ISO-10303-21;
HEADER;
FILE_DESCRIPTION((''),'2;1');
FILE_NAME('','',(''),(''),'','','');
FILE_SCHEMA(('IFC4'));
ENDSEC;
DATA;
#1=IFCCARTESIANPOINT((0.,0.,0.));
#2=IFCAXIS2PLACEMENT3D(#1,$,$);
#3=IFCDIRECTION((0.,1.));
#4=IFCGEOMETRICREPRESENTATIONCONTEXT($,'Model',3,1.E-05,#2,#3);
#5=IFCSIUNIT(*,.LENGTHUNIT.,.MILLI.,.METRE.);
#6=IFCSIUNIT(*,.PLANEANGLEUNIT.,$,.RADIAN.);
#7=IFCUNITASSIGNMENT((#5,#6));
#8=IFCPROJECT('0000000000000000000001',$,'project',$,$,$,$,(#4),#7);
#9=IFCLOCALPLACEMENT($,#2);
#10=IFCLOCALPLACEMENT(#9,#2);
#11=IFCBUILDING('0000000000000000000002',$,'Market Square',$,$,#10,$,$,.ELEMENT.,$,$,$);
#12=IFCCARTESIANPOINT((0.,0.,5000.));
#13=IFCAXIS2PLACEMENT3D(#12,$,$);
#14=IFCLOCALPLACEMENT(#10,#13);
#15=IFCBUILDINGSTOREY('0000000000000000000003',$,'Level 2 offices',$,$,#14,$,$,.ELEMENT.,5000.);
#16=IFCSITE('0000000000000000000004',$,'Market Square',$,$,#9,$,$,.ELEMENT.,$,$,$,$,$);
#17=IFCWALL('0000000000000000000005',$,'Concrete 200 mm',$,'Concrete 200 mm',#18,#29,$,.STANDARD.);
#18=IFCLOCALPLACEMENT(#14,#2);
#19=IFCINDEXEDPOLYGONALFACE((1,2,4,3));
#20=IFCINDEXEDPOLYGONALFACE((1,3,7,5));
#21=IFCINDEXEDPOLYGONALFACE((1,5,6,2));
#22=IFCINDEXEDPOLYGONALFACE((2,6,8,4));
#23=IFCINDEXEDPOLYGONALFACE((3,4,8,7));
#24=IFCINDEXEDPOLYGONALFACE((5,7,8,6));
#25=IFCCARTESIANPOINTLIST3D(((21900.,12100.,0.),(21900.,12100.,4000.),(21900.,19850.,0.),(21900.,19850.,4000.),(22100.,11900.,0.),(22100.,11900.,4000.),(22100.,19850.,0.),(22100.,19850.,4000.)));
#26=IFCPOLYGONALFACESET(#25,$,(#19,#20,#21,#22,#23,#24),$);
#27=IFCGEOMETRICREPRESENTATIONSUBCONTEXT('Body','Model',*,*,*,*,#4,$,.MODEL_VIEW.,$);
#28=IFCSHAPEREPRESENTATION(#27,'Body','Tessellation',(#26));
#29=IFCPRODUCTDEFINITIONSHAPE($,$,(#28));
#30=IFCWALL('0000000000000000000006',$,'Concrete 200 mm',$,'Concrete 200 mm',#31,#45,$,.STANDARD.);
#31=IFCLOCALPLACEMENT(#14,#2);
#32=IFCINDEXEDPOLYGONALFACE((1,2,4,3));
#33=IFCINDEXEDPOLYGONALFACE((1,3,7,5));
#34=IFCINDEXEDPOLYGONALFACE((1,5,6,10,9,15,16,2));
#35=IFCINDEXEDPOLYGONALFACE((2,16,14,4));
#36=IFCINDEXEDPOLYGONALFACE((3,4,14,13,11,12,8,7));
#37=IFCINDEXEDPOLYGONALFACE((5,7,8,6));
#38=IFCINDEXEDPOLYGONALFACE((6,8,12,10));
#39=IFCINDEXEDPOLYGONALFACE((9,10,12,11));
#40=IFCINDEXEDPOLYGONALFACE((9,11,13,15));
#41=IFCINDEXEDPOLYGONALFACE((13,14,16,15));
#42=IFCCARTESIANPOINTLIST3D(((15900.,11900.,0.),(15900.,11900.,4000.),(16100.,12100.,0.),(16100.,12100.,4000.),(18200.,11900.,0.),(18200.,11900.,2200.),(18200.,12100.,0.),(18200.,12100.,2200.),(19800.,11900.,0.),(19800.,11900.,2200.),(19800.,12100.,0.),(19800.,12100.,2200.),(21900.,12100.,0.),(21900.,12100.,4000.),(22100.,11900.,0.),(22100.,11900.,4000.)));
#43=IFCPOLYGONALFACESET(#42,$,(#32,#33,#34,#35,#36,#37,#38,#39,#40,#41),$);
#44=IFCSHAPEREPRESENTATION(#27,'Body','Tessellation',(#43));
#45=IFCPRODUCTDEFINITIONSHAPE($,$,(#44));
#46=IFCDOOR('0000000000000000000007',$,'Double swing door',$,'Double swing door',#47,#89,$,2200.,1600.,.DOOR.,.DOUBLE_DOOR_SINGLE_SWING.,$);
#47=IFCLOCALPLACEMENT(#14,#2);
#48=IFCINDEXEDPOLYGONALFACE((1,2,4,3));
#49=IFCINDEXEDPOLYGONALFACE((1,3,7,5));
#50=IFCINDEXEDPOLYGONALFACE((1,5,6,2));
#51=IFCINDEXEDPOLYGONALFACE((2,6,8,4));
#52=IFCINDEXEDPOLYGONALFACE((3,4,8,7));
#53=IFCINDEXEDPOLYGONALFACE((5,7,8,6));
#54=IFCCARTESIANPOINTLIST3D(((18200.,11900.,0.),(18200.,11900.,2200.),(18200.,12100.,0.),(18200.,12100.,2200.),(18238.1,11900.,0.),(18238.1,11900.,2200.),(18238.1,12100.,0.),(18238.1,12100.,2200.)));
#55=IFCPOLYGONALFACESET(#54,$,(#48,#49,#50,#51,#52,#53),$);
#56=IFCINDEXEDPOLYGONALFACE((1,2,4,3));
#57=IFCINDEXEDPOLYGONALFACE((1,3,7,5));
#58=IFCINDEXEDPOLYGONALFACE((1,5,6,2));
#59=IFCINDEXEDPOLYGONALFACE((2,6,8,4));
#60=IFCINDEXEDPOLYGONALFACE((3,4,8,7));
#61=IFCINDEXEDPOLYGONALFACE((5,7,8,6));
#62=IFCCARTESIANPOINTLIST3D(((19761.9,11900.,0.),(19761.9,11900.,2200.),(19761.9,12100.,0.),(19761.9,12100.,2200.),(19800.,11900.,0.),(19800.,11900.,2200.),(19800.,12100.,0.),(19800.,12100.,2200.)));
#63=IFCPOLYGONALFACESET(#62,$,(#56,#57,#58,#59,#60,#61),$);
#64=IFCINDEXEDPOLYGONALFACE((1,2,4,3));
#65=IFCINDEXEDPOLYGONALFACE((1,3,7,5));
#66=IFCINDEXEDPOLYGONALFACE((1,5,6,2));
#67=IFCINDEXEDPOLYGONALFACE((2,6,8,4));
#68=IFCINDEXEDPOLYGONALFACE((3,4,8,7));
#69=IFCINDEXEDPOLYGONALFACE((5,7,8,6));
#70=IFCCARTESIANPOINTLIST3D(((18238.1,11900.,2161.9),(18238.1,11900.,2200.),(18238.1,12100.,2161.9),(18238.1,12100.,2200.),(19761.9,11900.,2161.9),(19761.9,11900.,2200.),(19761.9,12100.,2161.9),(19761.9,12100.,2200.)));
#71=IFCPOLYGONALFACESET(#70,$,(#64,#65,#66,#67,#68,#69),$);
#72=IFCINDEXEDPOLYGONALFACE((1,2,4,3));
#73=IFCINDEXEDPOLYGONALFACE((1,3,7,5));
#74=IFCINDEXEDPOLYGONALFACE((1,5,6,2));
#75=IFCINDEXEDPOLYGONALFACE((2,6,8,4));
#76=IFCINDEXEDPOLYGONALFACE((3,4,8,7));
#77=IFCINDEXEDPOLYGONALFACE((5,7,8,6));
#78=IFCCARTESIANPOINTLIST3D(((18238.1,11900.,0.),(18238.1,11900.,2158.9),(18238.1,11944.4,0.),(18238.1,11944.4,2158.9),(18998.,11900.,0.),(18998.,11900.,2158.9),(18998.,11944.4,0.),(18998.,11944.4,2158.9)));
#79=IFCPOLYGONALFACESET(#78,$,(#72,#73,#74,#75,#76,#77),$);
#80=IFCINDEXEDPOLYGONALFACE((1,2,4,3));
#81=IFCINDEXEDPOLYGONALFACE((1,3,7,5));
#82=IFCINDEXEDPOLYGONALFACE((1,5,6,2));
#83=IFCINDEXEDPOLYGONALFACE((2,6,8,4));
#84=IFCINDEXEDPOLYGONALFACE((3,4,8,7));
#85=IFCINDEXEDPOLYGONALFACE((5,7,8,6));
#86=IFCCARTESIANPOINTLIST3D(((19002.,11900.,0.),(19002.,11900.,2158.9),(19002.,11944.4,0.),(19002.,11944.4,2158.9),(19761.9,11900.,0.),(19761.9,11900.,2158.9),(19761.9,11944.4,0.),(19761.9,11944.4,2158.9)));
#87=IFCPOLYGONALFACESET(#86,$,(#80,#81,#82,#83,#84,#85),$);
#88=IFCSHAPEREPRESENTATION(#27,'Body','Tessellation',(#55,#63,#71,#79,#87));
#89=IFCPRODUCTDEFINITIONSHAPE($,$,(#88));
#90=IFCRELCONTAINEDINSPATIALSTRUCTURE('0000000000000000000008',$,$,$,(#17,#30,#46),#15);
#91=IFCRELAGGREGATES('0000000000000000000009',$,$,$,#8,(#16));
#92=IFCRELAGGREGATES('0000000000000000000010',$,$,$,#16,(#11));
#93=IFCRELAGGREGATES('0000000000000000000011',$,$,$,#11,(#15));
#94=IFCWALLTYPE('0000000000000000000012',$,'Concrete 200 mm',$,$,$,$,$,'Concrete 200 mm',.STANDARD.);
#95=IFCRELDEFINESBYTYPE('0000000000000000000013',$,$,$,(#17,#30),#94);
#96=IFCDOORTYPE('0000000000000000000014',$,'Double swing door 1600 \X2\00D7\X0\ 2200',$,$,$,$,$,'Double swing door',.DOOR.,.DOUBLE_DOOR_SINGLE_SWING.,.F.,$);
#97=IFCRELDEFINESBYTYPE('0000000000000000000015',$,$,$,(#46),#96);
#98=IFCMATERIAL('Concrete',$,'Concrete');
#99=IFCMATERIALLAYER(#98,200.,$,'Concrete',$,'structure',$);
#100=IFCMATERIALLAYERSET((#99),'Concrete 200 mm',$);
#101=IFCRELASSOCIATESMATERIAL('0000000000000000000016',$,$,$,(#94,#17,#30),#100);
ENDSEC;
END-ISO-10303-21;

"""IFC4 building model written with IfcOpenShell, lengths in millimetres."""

from ifc_helpers import new_model, si_unit, direction, frame, origin, origin_with_axes, place, context, subcontext, project, spatial, polyline, outline, extrude, material, layer, layer_set, layer_usage, type_object, element, fill, save


model = new_model("IFC4")

# Units and contexts
model_context = context("Model", 3, precision=1e-05, world=origin(), true_north=direction((0.0, 1.0)))
body_context = subcontext(model_context, "Body", "Model", "MODEL_VIEW")
ifc_project = project(units=[si_unit("LENGTHUNIT", "METRE", prefix="MILLI"), si_unit("PLANEANGLEUNIT", "RADIAN")], contexts=[model_context])

# Site, building, storey
site_placement = place(None, origin())
site = spatial("IfcSite", under=ifc_project, at=site_placement, Name="Market Square", CompositionType="ELEMENT")
building_placement = place(site_placement, origin())
building = spatial("IfcBuilding", under=site, at=building_placement, Name="Market Square", CompositionType="ELEMENT")
storey_placement = place(building_placement, frame((0.0, 0.0, 5000.0)))
storey = spatial("IfcBuildingStorey", under=building, at=storey_placement, Name="Level 2 offices", CompositionType="ELEMENT", Elevation=5000.0)

# Wall
ifc_material_1 = material(Name="Concrete", Category="Concrete")
ifc_layer_1 = layer(ifc_material_1, 200.0, Name="Concrete", Category="structure")
ifc_layer_set_1 = layer_set([ifc_layer_1], Name="Concrete 200 mm")
ifc_layer_usage_1 = layer_usage(ifc_layer_set_1, "AXIS2", "NEGATIVE", 100.0)
wall_type_1 = type_object("IfcWallType", Name="Concrete 200 mm", ElementType="Concrete 200 mm", PredefinedType="STANDARD", material=ifc_layer_set_1)
wall_1_placement = place(storey_placement, frame((22000.0, 12000.0, 0.0), z_axis=(0.0, 0.0, 1.0), x_axis=(0.0, 1.0, 0.0)))
element("IfcWall", 1, at=wall_1_placement, inside=storey, type_object=wall_type_1, material=ifc_layer_usage_1, Name="Concrete 200 mm", ObjectType="Concrete 200 mm", PredefinedType="STANDARD", context=body_context, shape_type="SweptSolid", body=[
    extrude(outline(polyline([(-100.0, -100.0), (7850.0, -100.0), (7850.0, 100.0), (100.0, 100.0), (-100.0, -100.0)])), origin(), (0.0, 0.0, 1.0), 4000.0),
])

# Wall, opening, door
ifc_layer_usage_2 = layer_usage(ifc_layer_set_1, "AXIS2", "NEGATIVE", 100.0)
wall_2_placement = place(storey_placement, frame((16000.0, 12000.0, 0.0), z_axis=(0.0, 0.0, 1.0), x_axis=(1.0, 0.0, 0.0)))
wall_2 = element("IfcWall", 2, at=wall_2_placement, inside=storey, type_object=wall_type_1, material=ifc_layer_usage_2, Name="Concrete 200 mm", ObjectType="Concrete 200 mm", PredefinedType="STANDARD", context=body_context, shape_type="SweptSolid", body=[
    extrude(outline(polyline([(-100.0, -100.0), (6100.0, -100.0), (5900.0, 100.0), (100.0, 100.0), (-100.0, -100.0)])), origin(), (0.0, 0.0, 1.0), 4000.0),
])
opening_1_placement = place(wall_2_placement, frame((2200.0, 0.0, 0.0), z_axis=(0.0, 0.0, 1.0), x_axis=(1.0, 0.0, 0.0)))
opening_1 = element("IfcOpeningElement", 3, at=opening_1_placement, cuts=wall_2, PredefinedType="OPENING", context=body_context, shape_type="SweptSolid", body=[
    extrude(outline(polyline([(0.0, -110.0), (1600.0, -110.0), (1600.0, 110.0), (0.0, 110.0), (0.0, -110.0)])), origin(), (0.0, 0.0, 1.0), 2200.0),
])
door_type = type_object("IfcDoorType", Name="Double swing door 1600 × 2200", ElementType="Double swing door", OperationType="DOUBLE_DOOR_SINGLE_SWING", ParameterTakesPrecedence=False, PredefinedType="DOOR")
door_placement = place(opening_1_placement, origin_with_axes())
door = element("IfcDoor", 4, at=door_placement, inside=storey, type_object=door_type, Name="Double swing door", ObjectType="Double swing door", OperationType="DOUBLE_DOOR_SINGLE_SWING", OverallHeight=2200.0, OverallWidth=1600.0, PredefinedType="DOOR", context=body_context, shape_type="SweptSolid", body=[
    extrude(outline(polyline([(0.0, -100.0), (38.1, -100.0), (38.1, 100.0), (0.0, 100.0), (0.0, -100.0)])), origin(), (0.0, 0.0, 1.0), 2200.0),
    extrude(outline(polyline([(1561.9, -100.0), (1600.0, -100.0), (1600.0, 100.0), (1561.9, 100.0), (1561.9, -100.0)])), origin(), (0.0, 0.0, 1.0), 2200.0),
    extrude(outline(polyline([(38.1, -100.0), (1561.9, -100.0), (1561.9, 100.0), (38.1, 100.0), (38.1, -100.0)])), frame((0.0, 0.0, 2161.9)), (0.0, 0.0, 1.0), 38.1),
    extrude(outline(polyline([(38.1, -100.0), (798.0, -100.0), (798.0, -55.5), (38.1, -55.5), (38.1, -100.0)])), origin(), (0.0, 0.0, 1.0), 2158.9),
    extrude(outline(polyline([(802.0, -100.0), (1561.9, -100.0), (1561.9, -55.5), (802.0, -55.5), (802.0, -100.0)])), origin(), (0.0, 0.0, 1.0), 2158.9),
])
fill(opening_1, door)

save(model, "model.ifc")
